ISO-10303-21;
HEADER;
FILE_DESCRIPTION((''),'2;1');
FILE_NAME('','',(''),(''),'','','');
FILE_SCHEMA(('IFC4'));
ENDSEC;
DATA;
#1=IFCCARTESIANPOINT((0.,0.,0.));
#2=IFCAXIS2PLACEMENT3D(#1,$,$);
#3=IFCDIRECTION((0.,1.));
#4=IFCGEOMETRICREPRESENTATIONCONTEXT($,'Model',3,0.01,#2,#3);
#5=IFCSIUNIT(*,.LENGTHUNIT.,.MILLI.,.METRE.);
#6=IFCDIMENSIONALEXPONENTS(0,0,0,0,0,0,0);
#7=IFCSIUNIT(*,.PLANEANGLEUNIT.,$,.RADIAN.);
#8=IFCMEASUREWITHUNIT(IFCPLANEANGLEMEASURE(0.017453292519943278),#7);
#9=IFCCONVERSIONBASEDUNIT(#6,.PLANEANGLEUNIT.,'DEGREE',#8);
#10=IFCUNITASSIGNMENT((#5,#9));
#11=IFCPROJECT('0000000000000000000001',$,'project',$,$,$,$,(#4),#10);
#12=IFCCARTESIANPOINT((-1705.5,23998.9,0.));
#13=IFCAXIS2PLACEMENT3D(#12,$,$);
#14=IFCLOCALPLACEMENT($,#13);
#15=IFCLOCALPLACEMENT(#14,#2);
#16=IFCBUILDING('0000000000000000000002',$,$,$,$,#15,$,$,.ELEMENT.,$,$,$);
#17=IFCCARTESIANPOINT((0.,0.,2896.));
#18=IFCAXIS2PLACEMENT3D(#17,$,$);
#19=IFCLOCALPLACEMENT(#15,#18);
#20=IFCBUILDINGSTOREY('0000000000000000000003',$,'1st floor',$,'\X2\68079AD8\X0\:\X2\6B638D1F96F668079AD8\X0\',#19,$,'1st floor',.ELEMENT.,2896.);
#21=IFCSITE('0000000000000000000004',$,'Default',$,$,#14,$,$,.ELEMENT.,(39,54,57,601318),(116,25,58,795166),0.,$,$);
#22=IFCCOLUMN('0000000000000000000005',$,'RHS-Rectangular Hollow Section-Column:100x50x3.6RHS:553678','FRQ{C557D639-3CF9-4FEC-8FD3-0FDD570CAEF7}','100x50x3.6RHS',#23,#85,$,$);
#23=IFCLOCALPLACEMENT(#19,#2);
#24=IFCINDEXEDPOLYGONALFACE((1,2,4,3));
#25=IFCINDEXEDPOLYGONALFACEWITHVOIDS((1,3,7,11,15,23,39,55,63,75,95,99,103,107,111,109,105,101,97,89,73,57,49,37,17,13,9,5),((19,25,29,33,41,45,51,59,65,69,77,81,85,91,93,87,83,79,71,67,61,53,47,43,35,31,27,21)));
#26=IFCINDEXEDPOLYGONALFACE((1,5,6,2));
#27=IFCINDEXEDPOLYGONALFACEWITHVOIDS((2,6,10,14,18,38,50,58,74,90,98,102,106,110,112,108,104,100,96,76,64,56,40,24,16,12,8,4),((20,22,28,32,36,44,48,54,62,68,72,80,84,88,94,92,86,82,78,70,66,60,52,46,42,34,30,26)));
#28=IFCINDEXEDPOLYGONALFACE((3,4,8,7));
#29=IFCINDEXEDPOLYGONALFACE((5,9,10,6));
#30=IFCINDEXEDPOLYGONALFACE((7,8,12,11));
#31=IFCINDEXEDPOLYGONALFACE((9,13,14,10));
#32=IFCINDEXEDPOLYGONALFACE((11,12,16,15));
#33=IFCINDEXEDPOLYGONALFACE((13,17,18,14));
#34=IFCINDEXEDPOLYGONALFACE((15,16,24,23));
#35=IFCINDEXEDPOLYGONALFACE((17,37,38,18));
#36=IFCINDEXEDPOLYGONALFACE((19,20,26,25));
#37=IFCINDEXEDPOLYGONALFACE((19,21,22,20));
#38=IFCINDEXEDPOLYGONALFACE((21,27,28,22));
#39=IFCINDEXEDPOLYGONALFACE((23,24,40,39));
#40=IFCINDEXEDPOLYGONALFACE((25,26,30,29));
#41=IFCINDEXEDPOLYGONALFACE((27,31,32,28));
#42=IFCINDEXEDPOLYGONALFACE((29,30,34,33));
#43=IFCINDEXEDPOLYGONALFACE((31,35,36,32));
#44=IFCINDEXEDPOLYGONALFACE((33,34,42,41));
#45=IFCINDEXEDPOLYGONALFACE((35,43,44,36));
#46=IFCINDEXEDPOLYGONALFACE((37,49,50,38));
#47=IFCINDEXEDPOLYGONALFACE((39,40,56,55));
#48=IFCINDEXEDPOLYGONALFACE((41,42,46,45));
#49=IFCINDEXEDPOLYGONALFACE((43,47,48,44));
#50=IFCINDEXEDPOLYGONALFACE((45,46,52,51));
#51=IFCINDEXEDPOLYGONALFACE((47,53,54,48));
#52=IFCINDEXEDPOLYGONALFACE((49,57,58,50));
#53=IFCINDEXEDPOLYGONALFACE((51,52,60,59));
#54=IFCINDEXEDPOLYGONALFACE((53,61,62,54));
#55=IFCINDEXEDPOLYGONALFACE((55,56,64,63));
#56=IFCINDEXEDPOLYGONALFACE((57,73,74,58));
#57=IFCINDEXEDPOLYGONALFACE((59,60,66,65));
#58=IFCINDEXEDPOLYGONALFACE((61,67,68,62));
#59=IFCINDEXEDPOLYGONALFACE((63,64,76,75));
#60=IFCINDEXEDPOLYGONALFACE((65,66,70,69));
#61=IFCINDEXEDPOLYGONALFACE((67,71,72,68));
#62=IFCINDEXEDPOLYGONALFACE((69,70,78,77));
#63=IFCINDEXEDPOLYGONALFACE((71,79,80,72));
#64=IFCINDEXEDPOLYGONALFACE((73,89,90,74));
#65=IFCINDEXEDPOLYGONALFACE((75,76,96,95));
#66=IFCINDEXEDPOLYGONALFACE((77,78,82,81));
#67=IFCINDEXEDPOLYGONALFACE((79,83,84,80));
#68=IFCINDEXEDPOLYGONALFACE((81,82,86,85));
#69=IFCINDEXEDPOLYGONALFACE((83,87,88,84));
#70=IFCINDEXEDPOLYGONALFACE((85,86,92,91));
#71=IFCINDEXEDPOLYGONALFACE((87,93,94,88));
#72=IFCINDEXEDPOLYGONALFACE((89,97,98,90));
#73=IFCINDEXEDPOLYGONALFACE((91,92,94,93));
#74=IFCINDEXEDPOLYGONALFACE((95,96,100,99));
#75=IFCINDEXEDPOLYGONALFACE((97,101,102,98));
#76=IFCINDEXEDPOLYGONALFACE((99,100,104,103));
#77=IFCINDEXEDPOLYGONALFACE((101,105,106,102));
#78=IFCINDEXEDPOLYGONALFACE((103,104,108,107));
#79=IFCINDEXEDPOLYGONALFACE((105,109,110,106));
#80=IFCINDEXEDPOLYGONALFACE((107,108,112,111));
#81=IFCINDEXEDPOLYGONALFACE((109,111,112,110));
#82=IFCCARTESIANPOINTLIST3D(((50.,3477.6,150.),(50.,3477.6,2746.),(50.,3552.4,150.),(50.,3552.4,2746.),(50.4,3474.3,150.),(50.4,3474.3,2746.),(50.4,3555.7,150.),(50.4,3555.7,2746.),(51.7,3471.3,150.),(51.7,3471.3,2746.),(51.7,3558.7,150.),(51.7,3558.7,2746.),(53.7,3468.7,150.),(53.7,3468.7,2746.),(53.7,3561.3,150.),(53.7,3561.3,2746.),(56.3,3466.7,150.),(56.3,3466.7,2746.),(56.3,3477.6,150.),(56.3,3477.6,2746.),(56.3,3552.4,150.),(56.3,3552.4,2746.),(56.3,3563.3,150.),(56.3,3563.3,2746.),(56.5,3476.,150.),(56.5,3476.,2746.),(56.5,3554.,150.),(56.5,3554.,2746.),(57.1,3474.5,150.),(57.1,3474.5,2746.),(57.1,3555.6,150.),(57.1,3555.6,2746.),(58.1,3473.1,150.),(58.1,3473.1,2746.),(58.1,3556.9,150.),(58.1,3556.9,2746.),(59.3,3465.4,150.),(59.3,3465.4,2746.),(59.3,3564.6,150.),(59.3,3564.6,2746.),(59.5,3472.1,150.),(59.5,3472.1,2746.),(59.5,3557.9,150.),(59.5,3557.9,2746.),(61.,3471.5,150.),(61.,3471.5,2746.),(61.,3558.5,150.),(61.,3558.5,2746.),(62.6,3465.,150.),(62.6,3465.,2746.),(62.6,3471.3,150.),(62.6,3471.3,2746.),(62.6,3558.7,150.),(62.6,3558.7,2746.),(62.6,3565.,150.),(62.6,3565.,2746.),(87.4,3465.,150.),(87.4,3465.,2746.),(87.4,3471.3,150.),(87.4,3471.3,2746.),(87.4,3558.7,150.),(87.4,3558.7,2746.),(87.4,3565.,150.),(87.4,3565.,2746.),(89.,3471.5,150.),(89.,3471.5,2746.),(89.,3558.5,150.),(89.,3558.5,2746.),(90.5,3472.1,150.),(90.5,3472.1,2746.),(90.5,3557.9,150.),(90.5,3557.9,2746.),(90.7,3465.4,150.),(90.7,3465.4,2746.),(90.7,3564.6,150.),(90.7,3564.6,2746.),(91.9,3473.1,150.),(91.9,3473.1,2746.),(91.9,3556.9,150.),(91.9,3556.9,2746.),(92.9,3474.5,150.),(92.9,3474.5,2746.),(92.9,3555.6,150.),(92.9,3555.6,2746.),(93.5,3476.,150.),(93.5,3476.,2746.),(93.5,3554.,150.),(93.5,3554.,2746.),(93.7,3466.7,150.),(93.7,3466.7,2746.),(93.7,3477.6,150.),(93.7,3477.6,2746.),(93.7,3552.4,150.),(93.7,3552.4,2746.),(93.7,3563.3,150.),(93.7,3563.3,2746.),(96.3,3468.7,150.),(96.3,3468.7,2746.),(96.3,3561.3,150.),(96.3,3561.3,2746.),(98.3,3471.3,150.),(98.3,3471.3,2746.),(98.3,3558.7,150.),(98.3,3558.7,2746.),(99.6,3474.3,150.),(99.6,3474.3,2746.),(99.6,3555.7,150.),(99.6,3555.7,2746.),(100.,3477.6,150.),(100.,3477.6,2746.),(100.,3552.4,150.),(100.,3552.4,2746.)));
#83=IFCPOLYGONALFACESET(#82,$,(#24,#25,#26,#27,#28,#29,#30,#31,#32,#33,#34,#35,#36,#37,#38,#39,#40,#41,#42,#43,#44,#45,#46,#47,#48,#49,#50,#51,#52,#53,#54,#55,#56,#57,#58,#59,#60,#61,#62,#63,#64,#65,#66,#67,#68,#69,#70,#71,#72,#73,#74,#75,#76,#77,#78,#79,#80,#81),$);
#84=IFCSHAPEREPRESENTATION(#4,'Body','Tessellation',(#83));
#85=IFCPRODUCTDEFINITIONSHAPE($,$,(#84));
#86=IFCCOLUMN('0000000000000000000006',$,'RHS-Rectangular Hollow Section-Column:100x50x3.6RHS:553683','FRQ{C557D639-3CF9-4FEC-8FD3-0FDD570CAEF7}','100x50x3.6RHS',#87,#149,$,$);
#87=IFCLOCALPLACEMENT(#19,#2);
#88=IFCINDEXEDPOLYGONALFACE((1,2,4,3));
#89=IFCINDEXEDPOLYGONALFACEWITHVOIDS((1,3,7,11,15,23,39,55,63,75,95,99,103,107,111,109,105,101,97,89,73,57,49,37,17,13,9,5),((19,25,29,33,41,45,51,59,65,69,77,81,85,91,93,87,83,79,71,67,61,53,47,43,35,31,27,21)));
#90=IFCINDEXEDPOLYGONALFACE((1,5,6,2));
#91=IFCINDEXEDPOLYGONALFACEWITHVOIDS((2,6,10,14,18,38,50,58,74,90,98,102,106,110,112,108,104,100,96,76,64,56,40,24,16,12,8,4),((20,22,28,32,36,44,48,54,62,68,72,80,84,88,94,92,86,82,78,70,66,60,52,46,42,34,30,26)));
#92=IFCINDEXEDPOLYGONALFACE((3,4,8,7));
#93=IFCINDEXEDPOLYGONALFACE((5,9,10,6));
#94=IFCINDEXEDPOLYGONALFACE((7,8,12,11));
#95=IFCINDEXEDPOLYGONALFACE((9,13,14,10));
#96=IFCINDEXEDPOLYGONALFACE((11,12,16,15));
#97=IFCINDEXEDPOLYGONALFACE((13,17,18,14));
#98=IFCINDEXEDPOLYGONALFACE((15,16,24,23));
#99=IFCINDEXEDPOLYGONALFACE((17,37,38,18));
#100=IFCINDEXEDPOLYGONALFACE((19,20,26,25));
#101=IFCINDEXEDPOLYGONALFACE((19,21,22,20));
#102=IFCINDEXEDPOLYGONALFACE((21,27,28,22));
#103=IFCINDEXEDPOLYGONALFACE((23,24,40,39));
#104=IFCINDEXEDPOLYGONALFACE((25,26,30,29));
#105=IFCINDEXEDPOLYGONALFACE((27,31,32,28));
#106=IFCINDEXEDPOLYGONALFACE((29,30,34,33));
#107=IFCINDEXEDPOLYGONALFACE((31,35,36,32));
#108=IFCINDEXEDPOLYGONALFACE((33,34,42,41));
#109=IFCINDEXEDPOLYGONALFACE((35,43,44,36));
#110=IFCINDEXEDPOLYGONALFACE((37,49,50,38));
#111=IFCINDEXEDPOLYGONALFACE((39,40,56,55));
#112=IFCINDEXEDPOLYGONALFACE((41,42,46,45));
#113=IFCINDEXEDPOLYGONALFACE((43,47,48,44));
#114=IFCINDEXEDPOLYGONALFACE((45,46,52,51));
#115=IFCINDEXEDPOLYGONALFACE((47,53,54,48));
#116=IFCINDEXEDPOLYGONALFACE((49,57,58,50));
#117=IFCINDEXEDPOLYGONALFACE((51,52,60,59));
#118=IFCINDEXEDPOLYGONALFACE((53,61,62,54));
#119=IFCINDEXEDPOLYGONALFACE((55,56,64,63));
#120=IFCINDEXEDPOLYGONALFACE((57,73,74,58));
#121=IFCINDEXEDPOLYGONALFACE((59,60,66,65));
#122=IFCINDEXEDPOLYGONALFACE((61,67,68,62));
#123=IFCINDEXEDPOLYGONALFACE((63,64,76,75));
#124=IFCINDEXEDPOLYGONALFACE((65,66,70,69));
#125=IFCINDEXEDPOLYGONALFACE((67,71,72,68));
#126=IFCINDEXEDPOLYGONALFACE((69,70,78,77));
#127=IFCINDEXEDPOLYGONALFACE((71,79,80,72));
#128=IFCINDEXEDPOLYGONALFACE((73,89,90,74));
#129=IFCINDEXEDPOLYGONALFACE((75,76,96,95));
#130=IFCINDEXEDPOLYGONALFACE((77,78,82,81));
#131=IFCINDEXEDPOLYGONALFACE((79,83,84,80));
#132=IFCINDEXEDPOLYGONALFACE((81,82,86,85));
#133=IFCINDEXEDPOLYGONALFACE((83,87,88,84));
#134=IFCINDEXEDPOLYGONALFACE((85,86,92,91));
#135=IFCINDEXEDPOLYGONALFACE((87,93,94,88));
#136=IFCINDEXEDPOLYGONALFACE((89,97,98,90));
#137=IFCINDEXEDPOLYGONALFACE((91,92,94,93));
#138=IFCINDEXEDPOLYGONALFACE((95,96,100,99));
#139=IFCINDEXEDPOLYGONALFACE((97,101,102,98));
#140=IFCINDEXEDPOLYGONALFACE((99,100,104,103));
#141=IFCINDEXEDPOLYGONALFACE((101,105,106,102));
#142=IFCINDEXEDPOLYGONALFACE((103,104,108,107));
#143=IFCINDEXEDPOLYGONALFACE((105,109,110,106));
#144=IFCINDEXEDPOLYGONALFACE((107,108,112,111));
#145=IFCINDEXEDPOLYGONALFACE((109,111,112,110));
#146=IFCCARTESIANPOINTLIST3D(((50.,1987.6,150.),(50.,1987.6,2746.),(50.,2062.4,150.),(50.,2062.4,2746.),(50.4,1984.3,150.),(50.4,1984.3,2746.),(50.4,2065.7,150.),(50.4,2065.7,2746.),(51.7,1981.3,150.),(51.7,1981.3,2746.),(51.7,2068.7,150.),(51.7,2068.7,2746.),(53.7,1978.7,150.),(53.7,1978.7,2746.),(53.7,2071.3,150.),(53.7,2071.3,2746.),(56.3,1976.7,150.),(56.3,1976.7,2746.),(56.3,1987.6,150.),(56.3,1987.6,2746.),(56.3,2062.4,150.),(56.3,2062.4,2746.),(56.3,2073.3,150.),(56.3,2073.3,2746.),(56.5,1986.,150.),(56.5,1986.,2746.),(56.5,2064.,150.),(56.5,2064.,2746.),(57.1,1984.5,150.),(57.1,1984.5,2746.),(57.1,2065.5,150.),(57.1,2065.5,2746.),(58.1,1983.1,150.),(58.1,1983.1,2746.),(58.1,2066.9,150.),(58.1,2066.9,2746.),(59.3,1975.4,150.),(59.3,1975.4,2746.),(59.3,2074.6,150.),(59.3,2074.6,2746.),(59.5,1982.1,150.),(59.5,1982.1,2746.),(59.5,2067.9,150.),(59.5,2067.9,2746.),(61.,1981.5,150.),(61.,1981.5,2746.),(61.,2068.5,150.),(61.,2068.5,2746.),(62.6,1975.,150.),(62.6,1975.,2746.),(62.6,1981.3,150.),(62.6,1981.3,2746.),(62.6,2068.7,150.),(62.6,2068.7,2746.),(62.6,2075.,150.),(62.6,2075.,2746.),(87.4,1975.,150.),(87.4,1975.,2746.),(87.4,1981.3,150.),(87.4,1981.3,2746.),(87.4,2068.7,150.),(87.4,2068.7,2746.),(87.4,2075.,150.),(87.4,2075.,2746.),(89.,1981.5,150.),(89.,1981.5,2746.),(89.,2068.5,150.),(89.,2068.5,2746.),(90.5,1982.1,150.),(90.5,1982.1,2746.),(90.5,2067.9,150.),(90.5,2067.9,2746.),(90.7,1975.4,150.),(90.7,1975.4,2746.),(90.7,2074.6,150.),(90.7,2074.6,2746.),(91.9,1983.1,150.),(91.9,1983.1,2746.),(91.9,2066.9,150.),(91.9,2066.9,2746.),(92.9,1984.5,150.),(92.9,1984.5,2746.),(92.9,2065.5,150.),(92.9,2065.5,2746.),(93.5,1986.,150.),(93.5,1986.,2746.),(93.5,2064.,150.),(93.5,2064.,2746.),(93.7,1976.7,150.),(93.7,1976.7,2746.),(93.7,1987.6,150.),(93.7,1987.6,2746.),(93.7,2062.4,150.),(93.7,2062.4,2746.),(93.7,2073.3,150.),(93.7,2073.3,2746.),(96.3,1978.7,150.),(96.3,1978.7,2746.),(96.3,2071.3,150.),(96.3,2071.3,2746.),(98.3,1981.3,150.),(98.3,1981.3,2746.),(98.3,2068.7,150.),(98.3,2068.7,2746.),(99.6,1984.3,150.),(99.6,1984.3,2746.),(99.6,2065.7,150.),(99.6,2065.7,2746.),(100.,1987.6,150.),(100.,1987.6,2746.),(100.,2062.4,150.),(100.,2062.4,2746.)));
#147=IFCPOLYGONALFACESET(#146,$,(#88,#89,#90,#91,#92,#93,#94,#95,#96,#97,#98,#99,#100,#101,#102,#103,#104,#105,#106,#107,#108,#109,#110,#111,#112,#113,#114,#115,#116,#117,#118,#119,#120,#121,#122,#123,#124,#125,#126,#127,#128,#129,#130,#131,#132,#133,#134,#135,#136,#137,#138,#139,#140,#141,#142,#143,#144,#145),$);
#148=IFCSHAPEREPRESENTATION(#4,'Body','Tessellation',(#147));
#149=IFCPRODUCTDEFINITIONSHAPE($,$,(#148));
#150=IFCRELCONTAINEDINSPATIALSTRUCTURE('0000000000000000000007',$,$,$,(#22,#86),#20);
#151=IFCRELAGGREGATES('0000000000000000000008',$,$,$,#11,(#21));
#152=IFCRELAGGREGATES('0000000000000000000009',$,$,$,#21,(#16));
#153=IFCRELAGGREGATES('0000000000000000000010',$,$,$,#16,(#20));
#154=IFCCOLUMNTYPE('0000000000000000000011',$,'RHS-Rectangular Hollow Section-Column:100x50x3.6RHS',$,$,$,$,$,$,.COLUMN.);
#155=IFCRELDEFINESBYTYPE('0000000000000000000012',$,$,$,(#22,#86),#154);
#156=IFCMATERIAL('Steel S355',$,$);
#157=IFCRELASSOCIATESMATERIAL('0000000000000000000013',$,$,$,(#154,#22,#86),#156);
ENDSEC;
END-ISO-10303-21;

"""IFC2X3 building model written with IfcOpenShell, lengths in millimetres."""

from ifc_helpers import new_model, entity, si_unit, converted_unit, direction, frame, origin, origin_2d, place, context, project, spatial, hollow_rectangle, extrude, clip, halfspace, material, type_object, element, save


model = new_model("IFC2X3")

# Units and contexts
model_context = context("Model", 3, precision=0.01, world=origin(), true_north=direction((0.0, 1.0)))
ifc_project = project(units=[si_unit("LENGTHUNIT", "METRE", prefix="MILLI"), converted_unit("PLANEANGLEUNIT", "DEGREE", entity("IfcPlaneAngleMeasure", 0.017453292519943278), si_unit("PLANEANGLEUNIT", "RADIAN"), dimensions=[0, 0, 0, 0, 0, 0, 0])], contexts=[model_context])

# Site, building, storey
site_placement = place(None, frame((-1705.5, 23998.9, 0.0)))
site = spatial("IfcSite", under=ifc_project, at=site_placement, Name="Default", CompositionType="ELEMENT", RefLatitude=(39, 54, 57, 601318), RefLongitude=(116, 25, 58, 795166), RefElevation=0.0)
building_placement = place(site_placement, origin())
building = spatial("IfcBuilding", under=site, at=building_placement, CompositionType="ELEMENT")
storey_placement = place(building_placement, frame((0.0, 0.0, 2896.0)))
storey = spatial("IfcBuildingStorey", under=building, at=storey_placement, Name="1st floor", ObjectType="标高:正负零标高", LongName="1st floor", CompositionType="ELEMENT", Elevation=2896.0)

# Shared definitions
ifc_material_1 = material(Name="Steel S355")

# Columns
column_type_1 = type_object("IfcColumnType", Name="RHS-Rectangular Hollow Section-Column:100x50x3.6RHS", PredefinedType="COLUMN", material=ifc_material_1)
column_1_placement = place(storey_placement, frame((75.0, 3515.0, 2746.0), z_axis=(0.0, 0.0, 1.0), x_axis=(-1.0, 0.0, 0.0)))
element("IfcColumn", 1, at=column_1_placement, inside=storey, type_object=column_type_1, material=ifc_material_1, Name="RHS-Rectangular Hollow Section-Column:100x50x3.6RHS:553678", Description="FRQ{C557D639-3CF9-4FEC-8FD3-0FDD570CAEF7}", ObjectType="100x50x3.6RHS", context=model_context, shape_type="Clipping", body=[
    clip(extrude(hollow_rectangle(XDim=50.0, YDim=100.0, WallThickness=6.3, InnerFilletRadius=6.3, OuterFilletRadius=12.6, at=origin_2d()), origin(), (0.0, 0.0, -1.0), 2651.9), halfspace(frame((75.0, 3515.0, -2596.0), z_axis=(0.0, 0.0, 1.0), x_axis=(-1.0, 0.0, 0.0)), True)),
])
column_2_placement = place(storey_placement, frame((75.0, 2025.0, 2746.0), z_axis=(0.0, 0.0, 1.0), x_axis=(-1.0, 0.0, 0.0)))
element("IfcColumn", 2, at=column_2_placement, inside=storey, type_object=column_type_1, material=ifc_material_1, Name="RHS-Rectangular Hollow Section-Column:100x50x3.6RHS:553683", Description="FRQ{C557D639-3CF9-4FEC-8FD3-0FDD570CAEF7}", ObjectType="100x50x3.6RHS", context=model_context, shape_type="Clipping", body=[
    clip(extrude(hollow_rectangle(XDim=50.0, YDim=100.0, WallThickness=6.3, InnerFilletRadius=6.3, OuterFilletRadius=12.6, at=origin_2d()), origin(), (0.0, 0.0, -1.0), 2651.9), halfspace(frame((75.0, 2025.0, -2596.0), z_axis=(0.0, 0.0, 1.0), x_axis=(-1.0, 0.0, 0.0)), True)),
])

save(model, "model.ifc")
